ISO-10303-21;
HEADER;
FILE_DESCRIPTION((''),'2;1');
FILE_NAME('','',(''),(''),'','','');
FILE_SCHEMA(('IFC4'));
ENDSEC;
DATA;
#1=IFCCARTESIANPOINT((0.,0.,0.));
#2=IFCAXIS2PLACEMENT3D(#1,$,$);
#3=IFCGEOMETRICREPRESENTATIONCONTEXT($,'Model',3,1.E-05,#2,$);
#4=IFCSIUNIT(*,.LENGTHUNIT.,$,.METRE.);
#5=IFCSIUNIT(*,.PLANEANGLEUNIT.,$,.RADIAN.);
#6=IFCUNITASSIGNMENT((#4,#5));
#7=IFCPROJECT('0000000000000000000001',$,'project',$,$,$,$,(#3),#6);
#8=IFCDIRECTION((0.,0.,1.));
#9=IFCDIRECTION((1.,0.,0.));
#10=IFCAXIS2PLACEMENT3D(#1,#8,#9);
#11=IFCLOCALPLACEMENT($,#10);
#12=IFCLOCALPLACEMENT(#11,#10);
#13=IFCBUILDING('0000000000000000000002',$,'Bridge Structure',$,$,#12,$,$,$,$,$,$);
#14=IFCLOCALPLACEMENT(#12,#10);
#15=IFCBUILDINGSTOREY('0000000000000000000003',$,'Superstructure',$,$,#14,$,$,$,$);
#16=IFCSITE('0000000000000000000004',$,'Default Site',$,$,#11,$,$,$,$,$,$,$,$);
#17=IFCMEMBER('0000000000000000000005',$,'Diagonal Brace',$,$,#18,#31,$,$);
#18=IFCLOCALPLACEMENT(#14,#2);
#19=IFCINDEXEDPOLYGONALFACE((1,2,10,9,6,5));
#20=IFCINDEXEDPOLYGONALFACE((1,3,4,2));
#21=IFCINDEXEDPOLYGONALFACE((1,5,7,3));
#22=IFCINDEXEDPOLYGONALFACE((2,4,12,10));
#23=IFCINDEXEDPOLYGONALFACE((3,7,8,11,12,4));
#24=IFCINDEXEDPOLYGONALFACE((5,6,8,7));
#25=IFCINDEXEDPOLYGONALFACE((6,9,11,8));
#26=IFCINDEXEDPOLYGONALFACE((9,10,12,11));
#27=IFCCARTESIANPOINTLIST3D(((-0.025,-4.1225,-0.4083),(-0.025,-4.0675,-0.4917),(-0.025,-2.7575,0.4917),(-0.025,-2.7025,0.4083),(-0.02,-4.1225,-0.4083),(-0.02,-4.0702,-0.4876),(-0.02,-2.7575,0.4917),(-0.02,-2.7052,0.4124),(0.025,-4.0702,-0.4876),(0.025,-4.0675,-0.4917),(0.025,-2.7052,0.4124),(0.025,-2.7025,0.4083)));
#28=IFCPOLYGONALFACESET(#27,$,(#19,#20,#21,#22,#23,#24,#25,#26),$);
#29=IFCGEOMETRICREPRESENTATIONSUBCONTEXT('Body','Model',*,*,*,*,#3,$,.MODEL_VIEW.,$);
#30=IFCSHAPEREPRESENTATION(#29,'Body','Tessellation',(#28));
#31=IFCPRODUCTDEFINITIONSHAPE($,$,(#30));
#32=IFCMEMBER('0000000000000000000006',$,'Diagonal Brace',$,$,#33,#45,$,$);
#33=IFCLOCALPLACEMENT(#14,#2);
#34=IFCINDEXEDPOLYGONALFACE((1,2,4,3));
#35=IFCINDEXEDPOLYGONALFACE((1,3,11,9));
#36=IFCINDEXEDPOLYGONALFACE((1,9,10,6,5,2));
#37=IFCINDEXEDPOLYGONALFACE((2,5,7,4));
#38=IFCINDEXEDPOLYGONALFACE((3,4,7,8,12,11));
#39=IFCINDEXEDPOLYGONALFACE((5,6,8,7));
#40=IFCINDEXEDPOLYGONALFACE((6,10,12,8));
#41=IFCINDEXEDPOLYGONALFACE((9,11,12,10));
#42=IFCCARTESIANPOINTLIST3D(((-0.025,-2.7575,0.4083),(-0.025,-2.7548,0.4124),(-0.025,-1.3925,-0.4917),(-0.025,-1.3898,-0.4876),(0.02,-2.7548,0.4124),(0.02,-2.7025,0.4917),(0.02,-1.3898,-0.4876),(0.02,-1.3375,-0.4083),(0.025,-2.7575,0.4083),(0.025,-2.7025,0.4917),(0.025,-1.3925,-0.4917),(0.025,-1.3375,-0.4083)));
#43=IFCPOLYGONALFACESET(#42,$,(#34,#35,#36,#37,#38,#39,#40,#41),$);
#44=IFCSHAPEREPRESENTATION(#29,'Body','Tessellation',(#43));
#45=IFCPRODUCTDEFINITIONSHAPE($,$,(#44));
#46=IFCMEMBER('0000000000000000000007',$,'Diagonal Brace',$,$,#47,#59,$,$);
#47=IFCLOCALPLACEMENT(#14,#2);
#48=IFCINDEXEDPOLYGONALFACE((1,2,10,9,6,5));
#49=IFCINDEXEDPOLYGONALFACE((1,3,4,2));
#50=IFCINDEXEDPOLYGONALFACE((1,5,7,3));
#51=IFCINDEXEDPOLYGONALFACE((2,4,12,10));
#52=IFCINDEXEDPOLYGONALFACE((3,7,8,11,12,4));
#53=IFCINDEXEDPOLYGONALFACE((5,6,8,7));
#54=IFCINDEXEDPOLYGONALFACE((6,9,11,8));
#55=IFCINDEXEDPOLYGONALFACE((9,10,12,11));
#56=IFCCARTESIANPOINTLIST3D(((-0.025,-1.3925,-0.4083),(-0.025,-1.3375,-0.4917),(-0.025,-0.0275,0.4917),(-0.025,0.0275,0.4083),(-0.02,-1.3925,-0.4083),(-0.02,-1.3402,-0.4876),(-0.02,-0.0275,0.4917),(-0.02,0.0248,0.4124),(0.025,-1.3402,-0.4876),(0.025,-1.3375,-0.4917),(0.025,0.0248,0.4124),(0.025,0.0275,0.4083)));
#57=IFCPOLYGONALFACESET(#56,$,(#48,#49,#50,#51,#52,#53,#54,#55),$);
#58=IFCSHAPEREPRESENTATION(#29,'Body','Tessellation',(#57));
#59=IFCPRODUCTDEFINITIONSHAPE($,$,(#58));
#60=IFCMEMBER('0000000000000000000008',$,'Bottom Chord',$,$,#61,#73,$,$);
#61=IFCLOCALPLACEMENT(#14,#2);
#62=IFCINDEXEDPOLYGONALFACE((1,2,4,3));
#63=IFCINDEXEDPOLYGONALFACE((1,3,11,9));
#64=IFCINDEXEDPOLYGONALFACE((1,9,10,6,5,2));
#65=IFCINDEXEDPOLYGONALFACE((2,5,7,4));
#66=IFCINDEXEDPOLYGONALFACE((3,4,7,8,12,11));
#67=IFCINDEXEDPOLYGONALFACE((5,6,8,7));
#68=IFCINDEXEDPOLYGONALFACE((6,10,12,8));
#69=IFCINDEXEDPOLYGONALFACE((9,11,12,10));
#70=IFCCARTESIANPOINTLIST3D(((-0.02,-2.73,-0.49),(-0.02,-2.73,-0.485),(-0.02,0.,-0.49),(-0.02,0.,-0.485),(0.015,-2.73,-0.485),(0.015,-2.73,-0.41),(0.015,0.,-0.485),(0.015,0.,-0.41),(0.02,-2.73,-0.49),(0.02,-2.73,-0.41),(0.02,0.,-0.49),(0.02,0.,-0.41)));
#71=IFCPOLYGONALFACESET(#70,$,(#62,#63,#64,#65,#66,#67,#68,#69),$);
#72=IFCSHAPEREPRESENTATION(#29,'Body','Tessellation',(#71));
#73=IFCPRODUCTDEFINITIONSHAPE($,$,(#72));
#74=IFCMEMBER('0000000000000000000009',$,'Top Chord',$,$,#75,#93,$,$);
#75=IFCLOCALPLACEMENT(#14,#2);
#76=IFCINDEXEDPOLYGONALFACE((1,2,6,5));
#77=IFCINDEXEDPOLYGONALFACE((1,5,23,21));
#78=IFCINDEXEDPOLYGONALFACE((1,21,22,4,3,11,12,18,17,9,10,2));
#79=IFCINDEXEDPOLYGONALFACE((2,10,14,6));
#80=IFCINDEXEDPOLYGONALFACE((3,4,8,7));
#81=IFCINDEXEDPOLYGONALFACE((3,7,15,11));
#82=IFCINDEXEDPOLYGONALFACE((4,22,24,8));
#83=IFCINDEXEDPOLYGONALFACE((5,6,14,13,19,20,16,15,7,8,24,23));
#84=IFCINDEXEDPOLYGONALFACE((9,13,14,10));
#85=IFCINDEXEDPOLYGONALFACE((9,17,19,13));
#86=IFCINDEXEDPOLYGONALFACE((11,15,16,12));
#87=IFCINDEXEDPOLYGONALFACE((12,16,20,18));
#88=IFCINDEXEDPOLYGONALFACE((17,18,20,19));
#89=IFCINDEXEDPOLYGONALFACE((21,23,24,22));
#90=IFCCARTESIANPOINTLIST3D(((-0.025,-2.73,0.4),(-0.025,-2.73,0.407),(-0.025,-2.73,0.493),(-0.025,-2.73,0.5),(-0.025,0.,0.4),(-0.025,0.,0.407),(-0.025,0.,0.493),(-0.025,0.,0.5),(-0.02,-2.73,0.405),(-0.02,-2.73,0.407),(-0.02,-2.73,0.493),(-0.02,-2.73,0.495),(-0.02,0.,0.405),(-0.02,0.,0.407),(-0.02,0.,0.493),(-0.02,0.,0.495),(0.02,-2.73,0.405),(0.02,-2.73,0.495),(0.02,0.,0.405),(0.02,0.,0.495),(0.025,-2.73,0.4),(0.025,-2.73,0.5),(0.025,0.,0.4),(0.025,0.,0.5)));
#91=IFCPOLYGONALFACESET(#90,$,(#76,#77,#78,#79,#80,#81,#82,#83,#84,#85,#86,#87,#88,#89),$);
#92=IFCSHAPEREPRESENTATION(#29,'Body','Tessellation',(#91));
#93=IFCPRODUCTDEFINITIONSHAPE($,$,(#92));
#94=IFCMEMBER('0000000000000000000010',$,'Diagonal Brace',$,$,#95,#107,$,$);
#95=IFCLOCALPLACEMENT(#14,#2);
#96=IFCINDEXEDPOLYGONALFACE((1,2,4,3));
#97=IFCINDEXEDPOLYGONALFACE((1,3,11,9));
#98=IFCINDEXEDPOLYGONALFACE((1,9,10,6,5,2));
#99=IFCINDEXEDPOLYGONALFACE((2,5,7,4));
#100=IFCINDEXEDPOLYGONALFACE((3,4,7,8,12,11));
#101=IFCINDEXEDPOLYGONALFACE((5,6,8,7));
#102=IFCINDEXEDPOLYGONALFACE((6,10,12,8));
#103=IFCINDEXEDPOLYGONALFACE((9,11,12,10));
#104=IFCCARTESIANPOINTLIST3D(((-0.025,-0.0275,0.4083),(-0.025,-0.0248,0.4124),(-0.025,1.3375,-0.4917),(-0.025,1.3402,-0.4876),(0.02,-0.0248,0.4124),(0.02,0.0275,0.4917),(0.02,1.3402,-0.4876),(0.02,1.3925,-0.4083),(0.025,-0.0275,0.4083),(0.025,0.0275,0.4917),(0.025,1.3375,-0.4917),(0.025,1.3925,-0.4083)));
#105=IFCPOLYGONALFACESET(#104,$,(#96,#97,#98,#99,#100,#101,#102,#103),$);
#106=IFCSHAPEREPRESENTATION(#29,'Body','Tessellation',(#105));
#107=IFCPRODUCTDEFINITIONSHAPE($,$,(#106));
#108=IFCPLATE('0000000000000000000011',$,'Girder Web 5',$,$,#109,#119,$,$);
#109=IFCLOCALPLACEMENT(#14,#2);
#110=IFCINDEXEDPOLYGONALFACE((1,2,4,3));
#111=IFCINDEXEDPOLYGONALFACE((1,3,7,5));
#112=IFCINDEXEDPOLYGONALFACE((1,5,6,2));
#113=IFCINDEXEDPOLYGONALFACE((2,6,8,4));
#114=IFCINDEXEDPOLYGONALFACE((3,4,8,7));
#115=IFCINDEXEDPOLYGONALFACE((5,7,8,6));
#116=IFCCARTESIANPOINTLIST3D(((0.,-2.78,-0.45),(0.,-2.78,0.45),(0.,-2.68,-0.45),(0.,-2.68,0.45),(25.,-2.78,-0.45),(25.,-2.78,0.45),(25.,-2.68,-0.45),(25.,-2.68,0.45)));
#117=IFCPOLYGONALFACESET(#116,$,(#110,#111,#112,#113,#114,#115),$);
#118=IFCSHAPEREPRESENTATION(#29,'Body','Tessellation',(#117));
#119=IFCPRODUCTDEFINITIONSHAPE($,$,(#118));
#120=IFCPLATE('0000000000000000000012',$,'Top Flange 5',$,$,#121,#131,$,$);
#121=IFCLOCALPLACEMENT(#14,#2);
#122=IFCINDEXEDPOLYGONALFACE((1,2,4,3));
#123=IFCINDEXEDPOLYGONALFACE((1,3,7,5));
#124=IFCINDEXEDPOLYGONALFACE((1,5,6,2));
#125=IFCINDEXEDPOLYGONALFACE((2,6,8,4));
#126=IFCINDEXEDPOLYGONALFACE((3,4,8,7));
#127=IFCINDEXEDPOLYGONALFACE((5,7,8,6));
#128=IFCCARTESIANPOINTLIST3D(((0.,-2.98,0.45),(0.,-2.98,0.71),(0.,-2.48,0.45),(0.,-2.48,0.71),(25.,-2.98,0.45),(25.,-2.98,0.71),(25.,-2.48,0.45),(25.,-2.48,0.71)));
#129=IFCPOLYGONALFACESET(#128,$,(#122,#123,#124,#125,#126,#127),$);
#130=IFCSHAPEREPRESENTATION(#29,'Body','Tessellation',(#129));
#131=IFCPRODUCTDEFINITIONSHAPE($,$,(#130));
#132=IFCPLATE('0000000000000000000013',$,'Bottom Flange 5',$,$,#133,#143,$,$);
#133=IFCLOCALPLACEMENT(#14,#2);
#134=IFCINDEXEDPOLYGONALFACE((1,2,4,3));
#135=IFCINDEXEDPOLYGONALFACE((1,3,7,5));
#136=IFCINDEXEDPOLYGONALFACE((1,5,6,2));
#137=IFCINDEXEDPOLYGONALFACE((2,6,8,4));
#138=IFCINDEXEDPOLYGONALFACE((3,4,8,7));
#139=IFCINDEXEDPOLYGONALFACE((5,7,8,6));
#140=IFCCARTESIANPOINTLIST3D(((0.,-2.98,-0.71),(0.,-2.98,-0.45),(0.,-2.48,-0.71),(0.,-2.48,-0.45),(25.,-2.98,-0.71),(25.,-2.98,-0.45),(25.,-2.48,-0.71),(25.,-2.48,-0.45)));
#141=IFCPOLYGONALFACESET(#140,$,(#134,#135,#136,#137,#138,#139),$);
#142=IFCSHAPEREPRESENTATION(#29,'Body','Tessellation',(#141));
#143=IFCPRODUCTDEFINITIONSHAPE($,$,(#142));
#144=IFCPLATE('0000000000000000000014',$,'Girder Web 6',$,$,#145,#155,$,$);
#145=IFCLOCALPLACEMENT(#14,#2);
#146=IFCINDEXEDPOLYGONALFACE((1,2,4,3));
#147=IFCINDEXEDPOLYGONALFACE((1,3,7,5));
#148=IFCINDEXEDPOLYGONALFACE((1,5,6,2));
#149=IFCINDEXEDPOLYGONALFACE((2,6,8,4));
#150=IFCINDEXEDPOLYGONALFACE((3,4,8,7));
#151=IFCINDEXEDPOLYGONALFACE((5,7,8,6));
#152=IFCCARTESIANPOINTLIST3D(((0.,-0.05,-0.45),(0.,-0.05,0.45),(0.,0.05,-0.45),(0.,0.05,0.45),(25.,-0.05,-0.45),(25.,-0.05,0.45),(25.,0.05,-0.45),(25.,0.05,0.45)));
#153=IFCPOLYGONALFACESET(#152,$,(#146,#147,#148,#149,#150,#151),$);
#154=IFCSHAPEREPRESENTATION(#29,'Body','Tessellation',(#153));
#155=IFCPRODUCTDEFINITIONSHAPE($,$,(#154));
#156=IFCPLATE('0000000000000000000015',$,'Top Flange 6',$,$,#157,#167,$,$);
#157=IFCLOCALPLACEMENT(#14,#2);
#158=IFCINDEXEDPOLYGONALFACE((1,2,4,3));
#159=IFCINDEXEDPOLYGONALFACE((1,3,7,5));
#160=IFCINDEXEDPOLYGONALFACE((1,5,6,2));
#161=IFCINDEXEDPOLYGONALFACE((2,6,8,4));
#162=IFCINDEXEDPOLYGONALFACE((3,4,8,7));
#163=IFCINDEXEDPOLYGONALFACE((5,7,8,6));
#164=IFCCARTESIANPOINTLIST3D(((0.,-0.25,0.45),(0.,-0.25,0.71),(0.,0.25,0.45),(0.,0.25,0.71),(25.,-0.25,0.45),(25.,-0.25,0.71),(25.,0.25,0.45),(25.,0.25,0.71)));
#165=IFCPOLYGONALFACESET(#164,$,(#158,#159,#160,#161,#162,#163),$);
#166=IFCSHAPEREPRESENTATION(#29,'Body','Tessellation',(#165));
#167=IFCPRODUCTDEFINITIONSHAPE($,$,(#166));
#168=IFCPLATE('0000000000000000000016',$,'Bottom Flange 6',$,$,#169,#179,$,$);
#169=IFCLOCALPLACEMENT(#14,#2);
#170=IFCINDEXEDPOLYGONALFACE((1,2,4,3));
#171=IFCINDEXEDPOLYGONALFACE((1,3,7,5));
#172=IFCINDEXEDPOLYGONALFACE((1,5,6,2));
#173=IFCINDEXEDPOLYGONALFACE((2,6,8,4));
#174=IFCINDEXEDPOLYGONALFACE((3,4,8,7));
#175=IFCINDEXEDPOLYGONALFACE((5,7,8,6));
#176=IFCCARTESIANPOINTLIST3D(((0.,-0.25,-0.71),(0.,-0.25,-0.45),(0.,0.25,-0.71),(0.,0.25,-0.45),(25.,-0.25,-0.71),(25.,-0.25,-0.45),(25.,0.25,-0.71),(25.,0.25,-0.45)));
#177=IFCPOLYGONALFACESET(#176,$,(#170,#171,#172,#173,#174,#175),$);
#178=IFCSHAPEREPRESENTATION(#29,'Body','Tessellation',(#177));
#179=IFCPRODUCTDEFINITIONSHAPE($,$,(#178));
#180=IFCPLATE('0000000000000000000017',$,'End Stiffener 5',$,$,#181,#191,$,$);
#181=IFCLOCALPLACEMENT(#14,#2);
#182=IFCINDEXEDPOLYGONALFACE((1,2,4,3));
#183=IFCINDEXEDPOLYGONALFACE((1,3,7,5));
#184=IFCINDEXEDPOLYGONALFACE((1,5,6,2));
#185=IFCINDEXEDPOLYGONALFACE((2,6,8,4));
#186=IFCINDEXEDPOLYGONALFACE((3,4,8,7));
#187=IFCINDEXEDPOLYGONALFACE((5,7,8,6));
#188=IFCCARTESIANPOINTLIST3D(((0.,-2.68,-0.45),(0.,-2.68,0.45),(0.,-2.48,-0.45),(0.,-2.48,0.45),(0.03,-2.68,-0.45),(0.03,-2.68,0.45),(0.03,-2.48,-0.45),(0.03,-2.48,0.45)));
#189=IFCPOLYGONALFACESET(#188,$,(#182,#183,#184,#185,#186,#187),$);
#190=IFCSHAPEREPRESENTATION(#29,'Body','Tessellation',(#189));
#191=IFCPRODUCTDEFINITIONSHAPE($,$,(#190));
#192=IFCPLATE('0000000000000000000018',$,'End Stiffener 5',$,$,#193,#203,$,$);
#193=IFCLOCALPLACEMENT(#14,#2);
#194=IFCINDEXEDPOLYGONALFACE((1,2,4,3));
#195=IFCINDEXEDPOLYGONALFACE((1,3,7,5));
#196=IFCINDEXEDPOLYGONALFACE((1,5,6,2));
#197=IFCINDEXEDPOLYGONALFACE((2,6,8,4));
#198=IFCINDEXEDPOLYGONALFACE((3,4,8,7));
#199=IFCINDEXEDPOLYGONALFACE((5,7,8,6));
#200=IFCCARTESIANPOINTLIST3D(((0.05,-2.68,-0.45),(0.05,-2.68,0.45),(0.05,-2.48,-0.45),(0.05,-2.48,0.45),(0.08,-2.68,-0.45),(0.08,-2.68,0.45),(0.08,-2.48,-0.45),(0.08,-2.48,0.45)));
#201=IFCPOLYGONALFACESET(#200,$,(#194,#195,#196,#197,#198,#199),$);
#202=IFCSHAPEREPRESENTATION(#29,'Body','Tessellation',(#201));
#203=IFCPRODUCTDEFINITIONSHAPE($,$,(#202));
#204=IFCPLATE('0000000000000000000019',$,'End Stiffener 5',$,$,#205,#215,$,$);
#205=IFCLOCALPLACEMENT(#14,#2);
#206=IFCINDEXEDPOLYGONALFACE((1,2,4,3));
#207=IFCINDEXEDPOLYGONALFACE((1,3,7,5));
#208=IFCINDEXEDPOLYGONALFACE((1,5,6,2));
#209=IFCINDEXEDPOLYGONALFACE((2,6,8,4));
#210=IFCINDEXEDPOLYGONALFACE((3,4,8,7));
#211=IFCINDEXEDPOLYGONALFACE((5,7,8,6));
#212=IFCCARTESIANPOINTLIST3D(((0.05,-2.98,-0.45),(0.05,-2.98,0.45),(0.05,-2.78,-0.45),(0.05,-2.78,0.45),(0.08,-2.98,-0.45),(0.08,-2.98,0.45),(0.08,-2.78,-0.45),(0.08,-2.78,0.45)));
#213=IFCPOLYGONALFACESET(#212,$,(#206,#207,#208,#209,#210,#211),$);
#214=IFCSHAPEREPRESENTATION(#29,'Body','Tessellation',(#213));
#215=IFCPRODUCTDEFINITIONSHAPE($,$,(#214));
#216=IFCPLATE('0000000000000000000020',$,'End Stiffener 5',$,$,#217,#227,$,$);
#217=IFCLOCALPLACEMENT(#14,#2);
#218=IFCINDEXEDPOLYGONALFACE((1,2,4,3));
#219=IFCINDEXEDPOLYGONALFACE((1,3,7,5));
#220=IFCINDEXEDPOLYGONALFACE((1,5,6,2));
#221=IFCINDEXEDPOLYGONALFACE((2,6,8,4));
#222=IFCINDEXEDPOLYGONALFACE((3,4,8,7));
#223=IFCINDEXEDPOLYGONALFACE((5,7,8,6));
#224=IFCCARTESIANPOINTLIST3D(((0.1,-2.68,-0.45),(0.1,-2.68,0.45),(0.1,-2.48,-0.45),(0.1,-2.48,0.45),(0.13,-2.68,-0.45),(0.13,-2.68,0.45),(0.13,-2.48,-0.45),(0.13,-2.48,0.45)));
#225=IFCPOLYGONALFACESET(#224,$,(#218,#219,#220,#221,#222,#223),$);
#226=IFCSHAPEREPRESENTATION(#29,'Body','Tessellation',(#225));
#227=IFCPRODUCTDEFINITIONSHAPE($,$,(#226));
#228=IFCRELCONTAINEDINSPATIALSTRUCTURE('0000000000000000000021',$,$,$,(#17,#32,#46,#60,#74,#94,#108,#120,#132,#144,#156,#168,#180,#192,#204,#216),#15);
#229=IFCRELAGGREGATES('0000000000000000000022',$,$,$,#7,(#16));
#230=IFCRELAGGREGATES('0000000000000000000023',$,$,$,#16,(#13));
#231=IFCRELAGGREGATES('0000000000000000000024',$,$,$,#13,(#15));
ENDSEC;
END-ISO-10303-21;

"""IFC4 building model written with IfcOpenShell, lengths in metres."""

from ifc_helpers import new_model, si_unit, frame, origin, origin_with_axes, origin_2d_with_axis, place, context, subcontext, project, spatial, rectangle, l_section, c_section, extrude, element, save


model = new_model("IFC4")

# Units and contexts
model_context = context("Model", 3, precision=1e-05, world=origin())
body_context = subcontext(model_context, "Body", "Model", "MODEL_VIEW")
ifc_project = project(units=[si_unit("LENGTHUNIT", "METRE"), si_unit("PLANEANGLEUNIT", "RADIAN")], contexts=[model_context])

# Site, building, storey
site_placement = place(None, origin_with_axes())
site = spatial("IfcSite", under=ifc_project, at=site_placement, Name="Default Site")
building_placement = place(site_placement, origin_with_axes())
building = spatial("IfcBuilding", under=site, at=building_placement, Name="Bridge Structure")
storey_placement = place(building_placement, origin_with_axes())
storey = spatial("IfcBuildingStorey", under=building, at=storey_placement, Name="Superstructure")

# Members
for number, where, z_axis, x_axis, name in (
    (1, (0.0, -2.73, 0.45), (0.0, -0.834862, -0.550459), (1.0, 0.0, 0.0), "Diagonal Brace"),
    (2, (0.0, -2.73, 0.45), (0.0, 0.834862, -0.550459), (-1.0, 0.0, 0.0), "Diagonal Brace"),
    (3, (0.0, 0.0, 0.45), (0.0, -0.834862, -0.550459), (1.0, 0.0, 0.0), "Diagonal Brace"),
):
    element("IfcMember", number, at=place(storey_placement, frame(where, z_axis=z_axis, x_axis=x_axis)), inside=storey, Name=name, context=body_context, shape_type="SweptSolid", body=[
        extrude(l_section(Depth=0.1, Width=0.05, Thickness=0.005, at=origin_2d_with_axis()), origin_with_axes(), (0.0, 0.0, 1.0), 1.635),
    ])
member_1_placement = place(storey_placement, frame((0.0, -2.73, -0.45), z_axis=(0.0, 1.0, 0.0), x_axis=(-1.0, 0.0, 0.0)))
element("IfcMember", 4, at=member_1_placement, inside=storey, Name="Bottom Chord", context=body_context, shape_type="SweptSolid", body=[
    extrude(l_section(Depth=0.08, Width=0.04, Thickness=0.005, at=origin_2d_with_axis()), origin_with_axes(), (0.0, 0.0, 1.0), 2.73),
])
member_2_placement = place(storey_placement, frame((0.0, -2.73, 0.45), z_axis=(0.0, 1.0, 0.0), x_axis=(-1.0, 0.0, 0.0)))
element("IfcMember", 5, at=member_2_placement, inside=storey, Name="Top Chord", context=body_context, shape_type="SweptSolid", body=[
    extrude(c_section(Depth=0.1, Width=0.05, WallThickness=0.005, Girth=0.007, at=origin_2d_with_axis()), origin_with_axes(), (0.0, 0.0, 1.0), 2.73),
])
member_3_placement = place(storey_placement, frame((0.0, 0.0, 0.45), z_axis=(0.0, 0.834862, -0.550459), x_axis=(-1.0, 0.0, 0.0)))
element("IfcMember", 6, at=member_3_placement, inside=storey, Name="Diagonal Brace", context=body_context, shape_type="SweptSolid", body=[
    extrude(l_section(Depth=0.1, Width=0.05, Thickness=0.005, at=origin_2d_with_axis()), origin_with_axes(), (0.0, 0.0, 1.0), 1.635),
])

# Plates
plate_1_placement = place(storey_placement, frame((0.0, -2.73, 0.0), z_axis=(1.0, 0.0, 0.0), x_axis=(0.0, 1.0, 0.0)))
element("IfcPlate", 7, at=plate_1_placement, inside=storey, Name="Girder Web 5", context=body_context, shape_type="SweptSolid", body=[
    extrude(rectangle(XDim=0.1, YDim=0.9, at=origin_2d_with_axis()), origin_with_axes(), (0.0, 0.0, 1.0), 25.0),
])
for number, where, z_axis, x_axis, name in (
    (8, (0.0, -2.73, 0.58), (1.0, 0.0, 0.0), (0.0, 1.0, 0.0), "Top Flange 5"),
    (9, (0.0, -2.73, -0.58), (1.0, 0.0, 0.0), (0.0, 1.0, 0.0), "Bottom Flange 5"),
):
    element("IfcPlate", number, at=place(storey_placement, frame(where, z_axis=z_axis, x_axis=x_axis)), inside=storey, Name=name, context=body_context, shape_type="SweptSolid", body=[
        extrude(rectangle(XDim=0.5, YDim=0.26, at=origin_2d_with_axis()), origin_with_axes(), (0.0, 0.0, 1.0), 25.0),
    ])
plate_2_placement = place(storey_placement, frame((0.0, 0.0, 0.0), z_axis=(1.0, 0.0, 0.0), x_axis=(0.0, 1.0, 0.0)))
element("IfcPlate", 10, at=plate_2_placement, inside=storey, Name="Girder Web 6", context=body_context, shape_type="SweptSolid", body=[
    extrude(rectangle(XDim=0.1, YDim=0.9, at=origin_2d_with_axis()), origin_with_axes(), (0.0, 0.0, 1.0), 25.0),
])
for number, where, z_axis, x_axis, name in (
    (11, (0.0, 0.0, 0.58), (1.0, 0.0, 0.0), (0.0, 1.0, 0.0), "Top Flange 6"),
    (12, (0.0, 0.0, -0.58), (1.0, 0.0, 0.0), (0.0, 1.0, 0.0), "Bottom Flange 6"),
):
    element("IfcPlate", number, at=place(storey_placement, frame(where, z_axis=z_axis, x_axis=x_axis)), inside=storey, Name=name, context=body_context, shape_type="SweptSolid", body=[
        extrude(rectangle(XDim=0.5, YDim=0.26, at=origin_2d_with_axis()), origin_with_axes(), (0.0, 0.0, 1.0), 25.0),
    ])
for number, where, z_axis, x_axis, name in (
    (13, (0.015, -2.58, -0.45), (0.0, 0.0, 1.0), (1.0, 0.0, 0.0), "End Stiffener 5"),
    (14, (0.065, -2.58, -0.45), (0.0, 0.0, 1.0), (1.0, 0.0, 0.0), "End Stiffener 5"),
    (15, (0.065, -2.88, -0.45), (0.0, 0.0, 1.0), (1.0, 0.0, 0.0), "End Stiffener 5"),
    (16, (0.115, -2.58, -0.45), (0.0, 0.0, 1.0), (1.0, 0.0, 0.0), "End Stiffener 5"),
):
    element("IfcPlate", number, at=place(storey_placement, frame(where, z_axis=z_axis, x_axis=x_axis)), inside=storey, Name=name, context=body_context, shape_type="SweptSolid", body=[
        extrude(rectangle(XDim=0.03, YDim=0.2, at=origin_2d_with_axis()), origin_with_axes(), (0.0, 0.0, 1.0), 0.9),
    ])

save(model, "model.ifc")
